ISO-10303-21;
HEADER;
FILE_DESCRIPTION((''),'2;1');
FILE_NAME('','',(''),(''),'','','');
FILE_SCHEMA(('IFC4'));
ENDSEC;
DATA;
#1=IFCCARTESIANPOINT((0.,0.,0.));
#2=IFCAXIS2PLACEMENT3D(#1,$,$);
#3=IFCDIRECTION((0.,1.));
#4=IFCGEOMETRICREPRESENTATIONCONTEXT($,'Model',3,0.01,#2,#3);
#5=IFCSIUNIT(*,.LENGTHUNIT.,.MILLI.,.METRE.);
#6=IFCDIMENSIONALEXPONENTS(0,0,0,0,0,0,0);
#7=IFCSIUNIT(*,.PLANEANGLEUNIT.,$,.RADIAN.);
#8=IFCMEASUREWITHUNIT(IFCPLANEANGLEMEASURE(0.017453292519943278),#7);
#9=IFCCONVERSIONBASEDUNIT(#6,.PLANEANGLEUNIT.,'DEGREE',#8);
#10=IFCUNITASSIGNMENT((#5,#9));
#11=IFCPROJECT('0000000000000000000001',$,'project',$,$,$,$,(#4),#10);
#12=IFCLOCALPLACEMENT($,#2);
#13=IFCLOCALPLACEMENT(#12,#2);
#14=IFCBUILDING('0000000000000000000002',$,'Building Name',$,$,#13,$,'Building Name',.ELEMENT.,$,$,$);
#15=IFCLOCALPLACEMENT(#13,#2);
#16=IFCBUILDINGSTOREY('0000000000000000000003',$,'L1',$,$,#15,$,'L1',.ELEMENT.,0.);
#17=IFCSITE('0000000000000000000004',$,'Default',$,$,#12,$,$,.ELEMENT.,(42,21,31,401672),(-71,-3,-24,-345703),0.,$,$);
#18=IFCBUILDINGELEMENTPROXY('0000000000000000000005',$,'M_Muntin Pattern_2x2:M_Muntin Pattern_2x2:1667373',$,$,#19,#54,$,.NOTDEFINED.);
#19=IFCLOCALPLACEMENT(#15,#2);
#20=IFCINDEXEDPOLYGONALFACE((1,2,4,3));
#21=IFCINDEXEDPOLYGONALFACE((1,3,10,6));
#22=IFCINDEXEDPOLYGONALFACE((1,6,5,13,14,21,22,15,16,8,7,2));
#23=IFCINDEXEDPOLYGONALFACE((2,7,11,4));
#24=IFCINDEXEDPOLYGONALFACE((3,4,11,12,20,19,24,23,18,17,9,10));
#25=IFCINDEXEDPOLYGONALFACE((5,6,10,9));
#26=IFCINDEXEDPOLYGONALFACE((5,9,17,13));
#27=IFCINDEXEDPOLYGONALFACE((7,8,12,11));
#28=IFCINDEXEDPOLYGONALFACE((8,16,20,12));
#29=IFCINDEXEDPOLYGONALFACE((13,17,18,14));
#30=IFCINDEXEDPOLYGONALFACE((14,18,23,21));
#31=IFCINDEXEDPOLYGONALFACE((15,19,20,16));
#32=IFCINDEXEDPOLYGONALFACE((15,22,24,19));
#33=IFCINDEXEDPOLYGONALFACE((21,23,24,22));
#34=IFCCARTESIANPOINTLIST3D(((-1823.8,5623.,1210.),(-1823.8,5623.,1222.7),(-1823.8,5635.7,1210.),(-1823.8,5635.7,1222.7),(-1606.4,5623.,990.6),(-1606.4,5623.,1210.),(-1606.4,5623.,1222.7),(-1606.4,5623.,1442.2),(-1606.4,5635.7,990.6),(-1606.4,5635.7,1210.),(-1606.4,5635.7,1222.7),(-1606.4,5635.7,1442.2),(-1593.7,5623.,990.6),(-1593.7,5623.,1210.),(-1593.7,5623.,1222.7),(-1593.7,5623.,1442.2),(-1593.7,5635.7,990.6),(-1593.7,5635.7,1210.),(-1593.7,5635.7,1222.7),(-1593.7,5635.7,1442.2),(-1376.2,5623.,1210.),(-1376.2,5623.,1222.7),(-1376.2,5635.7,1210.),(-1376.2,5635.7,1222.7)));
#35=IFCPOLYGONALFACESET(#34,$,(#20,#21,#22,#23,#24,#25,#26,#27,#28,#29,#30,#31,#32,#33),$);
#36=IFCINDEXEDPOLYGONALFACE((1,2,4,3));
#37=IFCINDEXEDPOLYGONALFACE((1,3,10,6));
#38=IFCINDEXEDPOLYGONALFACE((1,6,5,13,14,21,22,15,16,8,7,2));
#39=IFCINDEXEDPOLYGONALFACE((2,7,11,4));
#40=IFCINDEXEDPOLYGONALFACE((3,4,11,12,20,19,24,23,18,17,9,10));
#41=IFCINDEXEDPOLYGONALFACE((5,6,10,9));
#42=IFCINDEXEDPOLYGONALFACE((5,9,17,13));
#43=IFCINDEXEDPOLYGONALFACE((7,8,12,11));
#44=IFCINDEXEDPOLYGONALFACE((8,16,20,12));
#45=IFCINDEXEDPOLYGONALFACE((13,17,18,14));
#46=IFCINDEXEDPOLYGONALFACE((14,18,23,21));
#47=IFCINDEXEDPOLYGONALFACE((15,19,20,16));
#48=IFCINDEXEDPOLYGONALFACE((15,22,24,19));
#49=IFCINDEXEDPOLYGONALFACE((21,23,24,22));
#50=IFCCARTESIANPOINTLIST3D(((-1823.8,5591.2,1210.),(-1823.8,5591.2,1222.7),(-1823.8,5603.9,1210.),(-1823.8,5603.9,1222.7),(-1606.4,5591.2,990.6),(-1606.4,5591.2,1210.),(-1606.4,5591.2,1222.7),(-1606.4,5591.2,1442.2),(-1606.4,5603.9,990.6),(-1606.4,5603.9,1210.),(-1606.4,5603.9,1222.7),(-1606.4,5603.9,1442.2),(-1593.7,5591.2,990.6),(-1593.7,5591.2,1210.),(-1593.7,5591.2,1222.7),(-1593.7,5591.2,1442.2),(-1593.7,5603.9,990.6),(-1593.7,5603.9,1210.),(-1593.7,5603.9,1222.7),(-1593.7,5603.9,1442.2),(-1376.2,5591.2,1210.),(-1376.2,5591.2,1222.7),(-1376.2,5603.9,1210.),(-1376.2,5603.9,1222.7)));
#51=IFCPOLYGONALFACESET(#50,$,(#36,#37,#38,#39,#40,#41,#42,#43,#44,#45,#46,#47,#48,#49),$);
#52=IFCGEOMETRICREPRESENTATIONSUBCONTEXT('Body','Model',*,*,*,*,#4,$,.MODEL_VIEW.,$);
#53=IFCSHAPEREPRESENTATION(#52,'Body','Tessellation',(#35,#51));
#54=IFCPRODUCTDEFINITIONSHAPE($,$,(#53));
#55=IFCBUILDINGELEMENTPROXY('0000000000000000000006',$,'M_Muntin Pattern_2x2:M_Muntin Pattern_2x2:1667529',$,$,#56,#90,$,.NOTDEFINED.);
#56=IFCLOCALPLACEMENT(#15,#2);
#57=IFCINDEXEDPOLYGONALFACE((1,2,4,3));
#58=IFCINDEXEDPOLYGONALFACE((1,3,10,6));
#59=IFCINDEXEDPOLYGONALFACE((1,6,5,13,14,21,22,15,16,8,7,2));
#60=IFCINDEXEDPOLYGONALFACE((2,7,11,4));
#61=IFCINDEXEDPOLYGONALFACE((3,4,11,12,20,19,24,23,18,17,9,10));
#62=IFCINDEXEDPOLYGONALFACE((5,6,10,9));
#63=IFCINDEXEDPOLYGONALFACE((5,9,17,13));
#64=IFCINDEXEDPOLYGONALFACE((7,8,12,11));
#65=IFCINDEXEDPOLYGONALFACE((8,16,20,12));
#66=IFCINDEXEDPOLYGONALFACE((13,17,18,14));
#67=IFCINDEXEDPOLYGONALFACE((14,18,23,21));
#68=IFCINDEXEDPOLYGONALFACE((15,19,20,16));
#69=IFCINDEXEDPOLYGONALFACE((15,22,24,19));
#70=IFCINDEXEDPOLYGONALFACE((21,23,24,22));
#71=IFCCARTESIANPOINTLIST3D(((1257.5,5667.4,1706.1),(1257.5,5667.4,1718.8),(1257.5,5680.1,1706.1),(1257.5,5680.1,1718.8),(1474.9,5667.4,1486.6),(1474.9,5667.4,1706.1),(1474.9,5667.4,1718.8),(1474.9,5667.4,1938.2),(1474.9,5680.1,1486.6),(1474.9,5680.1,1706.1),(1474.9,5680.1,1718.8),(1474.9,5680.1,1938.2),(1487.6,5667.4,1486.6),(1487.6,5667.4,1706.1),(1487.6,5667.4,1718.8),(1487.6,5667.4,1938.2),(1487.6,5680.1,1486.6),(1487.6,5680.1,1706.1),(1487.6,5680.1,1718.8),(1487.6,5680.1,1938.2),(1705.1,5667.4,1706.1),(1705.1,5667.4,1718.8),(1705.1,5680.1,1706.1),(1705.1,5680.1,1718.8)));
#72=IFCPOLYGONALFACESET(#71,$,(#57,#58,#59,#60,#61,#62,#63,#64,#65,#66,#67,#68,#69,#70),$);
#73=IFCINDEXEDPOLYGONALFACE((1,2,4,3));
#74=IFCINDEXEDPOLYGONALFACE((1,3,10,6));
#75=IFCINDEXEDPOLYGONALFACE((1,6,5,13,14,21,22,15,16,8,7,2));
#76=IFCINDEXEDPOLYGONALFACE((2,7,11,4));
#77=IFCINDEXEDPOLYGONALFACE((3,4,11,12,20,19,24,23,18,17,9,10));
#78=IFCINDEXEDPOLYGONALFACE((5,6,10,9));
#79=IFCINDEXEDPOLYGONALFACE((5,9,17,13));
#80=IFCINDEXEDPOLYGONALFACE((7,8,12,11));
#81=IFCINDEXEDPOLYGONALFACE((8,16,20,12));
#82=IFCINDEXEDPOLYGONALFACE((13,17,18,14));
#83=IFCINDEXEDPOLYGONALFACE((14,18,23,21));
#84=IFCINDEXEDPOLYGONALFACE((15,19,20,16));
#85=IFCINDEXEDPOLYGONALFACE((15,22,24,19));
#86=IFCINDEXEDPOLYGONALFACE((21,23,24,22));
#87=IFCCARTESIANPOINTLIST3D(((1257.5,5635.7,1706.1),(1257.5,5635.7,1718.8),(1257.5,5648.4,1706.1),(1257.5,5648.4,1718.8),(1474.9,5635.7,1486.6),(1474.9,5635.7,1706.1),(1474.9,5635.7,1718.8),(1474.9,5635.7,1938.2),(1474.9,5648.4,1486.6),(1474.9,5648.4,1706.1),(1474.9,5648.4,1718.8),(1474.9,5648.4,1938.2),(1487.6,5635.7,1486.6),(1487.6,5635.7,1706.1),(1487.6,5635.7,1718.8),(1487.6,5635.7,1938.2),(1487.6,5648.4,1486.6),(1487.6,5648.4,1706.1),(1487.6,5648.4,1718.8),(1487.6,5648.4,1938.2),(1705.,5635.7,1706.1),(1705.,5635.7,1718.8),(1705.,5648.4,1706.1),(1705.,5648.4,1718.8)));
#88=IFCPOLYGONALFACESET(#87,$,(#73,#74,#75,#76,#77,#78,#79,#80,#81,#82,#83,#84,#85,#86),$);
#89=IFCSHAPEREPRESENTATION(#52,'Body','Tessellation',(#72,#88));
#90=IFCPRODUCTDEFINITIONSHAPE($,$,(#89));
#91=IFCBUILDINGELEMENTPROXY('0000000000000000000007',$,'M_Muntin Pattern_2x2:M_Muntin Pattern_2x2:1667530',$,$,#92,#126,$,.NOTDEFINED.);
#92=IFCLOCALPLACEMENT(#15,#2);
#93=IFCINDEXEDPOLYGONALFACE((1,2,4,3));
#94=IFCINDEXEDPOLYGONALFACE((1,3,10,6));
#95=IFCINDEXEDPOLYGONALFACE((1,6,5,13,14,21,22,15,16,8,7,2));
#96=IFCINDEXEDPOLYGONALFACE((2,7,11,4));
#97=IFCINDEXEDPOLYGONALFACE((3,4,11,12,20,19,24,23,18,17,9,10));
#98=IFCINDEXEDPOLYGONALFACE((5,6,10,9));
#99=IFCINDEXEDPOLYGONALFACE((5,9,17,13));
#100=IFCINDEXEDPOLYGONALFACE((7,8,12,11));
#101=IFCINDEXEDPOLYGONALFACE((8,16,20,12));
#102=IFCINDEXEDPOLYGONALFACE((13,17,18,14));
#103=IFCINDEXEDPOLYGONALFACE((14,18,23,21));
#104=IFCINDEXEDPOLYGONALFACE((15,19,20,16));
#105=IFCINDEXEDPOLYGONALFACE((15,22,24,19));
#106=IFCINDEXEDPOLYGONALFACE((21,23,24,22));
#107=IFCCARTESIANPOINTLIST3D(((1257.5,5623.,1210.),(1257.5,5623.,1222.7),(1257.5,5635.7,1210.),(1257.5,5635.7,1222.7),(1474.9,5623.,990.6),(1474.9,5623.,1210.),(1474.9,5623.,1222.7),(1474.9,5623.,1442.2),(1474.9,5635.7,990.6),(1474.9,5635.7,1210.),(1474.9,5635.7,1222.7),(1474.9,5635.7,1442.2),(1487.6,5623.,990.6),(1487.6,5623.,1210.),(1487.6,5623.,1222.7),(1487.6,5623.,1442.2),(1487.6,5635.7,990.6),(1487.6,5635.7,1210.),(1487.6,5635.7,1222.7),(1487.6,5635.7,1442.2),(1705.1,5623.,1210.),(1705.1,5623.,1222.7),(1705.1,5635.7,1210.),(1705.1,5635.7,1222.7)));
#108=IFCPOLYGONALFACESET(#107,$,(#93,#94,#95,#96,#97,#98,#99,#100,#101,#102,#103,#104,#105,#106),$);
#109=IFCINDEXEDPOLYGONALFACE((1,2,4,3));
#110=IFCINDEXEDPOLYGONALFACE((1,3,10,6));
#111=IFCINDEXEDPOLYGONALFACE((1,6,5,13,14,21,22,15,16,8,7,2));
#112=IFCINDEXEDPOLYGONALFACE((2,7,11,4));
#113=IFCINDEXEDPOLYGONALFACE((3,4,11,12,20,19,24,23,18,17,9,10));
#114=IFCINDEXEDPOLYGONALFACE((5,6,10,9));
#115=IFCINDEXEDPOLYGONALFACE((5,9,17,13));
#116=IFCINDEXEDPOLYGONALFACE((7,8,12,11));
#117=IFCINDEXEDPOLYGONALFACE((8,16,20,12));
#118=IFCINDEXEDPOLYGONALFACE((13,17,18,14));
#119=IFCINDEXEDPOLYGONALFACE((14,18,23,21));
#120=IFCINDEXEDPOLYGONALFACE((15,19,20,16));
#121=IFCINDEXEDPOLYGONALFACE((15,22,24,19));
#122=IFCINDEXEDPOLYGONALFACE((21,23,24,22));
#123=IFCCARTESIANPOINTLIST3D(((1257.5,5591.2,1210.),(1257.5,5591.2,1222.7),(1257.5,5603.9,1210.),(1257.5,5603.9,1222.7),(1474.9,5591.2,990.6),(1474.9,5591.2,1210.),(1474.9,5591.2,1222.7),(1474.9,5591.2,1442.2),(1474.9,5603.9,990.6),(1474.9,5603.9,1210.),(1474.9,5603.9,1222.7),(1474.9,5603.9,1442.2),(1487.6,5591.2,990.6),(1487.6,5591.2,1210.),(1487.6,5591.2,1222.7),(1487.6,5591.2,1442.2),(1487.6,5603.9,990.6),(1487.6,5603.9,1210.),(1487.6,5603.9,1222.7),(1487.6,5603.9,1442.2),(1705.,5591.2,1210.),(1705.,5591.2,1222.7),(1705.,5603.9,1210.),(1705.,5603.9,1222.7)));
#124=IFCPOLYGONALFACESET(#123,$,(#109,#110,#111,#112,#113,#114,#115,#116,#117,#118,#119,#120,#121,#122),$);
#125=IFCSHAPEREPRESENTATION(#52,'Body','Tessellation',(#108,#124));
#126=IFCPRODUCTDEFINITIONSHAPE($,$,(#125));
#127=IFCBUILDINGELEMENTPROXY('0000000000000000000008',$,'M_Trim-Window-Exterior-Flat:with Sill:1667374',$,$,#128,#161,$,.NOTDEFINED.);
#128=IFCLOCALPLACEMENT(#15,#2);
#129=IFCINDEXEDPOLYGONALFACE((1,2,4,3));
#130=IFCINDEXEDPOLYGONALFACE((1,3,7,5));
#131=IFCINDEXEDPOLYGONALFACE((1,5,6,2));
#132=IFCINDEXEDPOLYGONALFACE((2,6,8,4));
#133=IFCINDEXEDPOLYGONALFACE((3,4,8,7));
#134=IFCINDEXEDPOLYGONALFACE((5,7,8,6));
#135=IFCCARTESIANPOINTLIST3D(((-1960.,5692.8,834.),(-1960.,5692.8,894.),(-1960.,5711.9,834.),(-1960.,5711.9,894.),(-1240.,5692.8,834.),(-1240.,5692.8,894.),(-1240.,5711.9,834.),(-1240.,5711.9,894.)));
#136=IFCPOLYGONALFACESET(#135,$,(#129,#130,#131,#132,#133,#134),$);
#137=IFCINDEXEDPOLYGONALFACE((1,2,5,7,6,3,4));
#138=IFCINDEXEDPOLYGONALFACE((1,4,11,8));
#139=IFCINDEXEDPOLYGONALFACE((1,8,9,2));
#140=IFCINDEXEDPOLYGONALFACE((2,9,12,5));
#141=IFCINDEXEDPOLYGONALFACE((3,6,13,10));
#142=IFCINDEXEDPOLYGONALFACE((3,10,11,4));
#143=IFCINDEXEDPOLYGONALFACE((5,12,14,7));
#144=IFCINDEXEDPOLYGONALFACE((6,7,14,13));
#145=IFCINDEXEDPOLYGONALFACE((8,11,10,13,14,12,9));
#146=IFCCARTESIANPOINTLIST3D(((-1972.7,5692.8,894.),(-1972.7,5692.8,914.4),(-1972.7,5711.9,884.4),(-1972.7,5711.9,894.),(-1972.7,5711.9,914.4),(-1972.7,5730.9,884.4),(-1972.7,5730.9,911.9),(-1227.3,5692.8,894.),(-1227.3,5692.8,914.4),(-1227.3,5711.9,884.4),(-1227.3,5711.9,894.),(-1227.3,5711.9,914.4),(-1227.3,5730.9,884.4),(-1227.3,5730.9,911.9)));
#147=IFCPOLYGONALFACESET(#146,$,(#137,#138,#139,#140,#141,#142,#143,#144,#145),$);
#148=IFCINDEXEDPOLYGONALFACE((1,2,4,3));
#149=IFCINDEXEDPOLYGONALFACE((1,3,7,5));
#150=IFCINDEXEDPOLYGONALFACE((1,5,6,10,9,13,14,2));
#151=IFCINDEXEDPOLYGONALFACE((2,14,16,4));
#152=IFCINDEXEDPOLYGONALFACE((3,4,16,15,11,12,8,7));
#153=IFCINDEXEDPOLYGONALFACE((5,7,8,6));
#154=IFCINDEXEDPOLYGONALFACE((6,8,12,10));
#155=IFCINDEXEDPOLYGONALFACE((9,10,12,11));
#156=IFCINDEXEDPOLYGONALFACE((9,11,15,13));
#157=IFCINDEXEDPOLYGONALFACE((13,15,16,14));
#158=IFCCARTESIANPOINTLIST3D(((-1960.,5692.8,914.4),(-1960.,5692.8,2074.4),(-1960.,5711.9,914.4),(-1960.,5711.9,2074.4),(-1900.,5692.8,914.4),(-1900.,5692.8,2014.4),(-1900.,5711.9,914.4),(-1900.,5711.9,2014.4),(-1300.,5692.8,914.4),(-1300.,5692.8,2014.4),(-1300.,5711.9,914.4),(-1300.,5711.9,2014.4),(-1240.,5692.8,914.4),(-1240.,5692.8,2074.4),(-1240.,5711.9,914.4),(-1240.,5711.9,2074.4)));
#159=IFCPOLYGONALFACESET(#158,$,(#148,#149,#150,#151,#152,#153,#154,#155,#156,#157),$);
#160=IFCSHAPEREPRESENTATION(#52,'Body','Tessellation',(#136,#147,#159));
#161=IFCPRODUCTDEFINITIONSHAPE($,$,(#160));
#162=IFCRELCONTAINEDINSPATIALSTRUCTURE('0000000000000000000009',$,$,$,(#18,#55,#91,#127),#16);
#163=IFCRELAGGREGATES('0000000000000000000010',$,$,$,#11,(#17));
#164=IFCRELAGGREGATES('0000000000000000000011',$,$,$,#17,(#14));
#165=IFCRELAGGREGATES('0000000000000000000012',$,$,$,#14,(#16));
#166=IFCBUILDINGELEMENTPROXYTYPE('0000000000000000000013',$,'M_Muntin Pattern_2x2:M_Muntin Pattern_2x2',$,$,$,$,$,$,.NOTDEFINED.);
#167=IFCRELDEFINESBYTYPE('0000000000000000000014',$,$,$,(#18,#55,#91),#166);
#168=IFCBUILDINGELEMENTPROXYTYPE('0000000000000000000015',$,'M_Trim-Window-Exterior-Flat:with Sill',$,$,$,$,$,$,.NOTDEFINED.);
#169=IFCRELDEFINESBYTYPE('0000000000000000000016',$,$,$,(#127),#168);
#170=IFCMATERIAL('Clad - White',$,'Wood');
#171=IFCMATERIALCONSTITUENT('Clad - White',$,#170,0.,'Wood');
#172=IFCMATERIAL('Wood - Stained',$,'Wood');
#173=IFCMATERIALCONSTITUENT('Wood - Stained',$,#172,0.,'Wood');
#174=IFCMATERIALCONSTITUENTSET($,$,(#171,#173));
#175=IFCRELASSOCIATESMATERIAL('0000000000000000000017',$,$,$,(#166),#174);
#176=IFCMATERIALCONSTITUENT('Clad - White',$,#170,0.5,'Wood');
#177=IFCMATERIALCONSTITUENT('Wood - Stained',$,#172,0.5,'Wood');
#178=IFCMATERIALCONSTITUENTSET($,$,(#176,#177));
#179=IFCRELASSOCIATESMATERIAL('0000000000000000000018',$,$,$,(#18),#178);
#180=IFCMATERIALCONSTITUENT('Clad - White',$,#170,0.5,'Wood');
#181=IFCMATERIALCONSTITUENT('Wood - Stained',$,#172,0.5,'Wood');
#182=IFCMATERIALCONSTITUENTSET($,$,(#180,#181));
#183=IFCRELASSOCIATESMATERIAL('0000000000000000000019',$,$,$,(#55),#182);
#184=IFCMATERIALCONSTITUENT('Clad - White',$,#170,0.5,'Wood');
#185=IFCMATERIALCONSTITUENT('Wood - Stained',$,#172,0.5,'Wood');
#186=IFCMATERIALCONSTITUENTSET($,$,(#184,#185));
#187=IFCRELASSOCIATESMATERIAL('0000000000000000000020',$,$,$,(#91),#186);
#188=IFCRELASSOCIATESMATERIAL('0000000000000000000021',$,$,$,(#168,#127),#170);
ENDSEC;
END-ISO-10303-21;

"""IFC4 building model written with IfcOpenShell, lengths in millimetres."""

from ifc_helpers import new_model, entity, si_unit, converted_unit, direction, frame, origin, place, context, subcontext, project, spatial, indexed_curve, outline, extrude, source, transform, mapped, material, constituent, constituent_set, type_object, type_shapes, element, save


model = new_model("IFC4")

# Units and contexts
model_context = context("Model", 3, precision=0.01, world=origin(), true_north=direction((0.0, 1.0)))
body_context = subcontext(model_context, "Body", "Model", "MODEL_VIEW")
ifc_project = project(units=[si_unit("LENGTHUNIT", "METRE", prefix="MILLI"), converted_unit("PLANEANGLEUNIT", "DEGREE", entity("IfcPlaneAngleMeasure", 0.017453292519943278), si_unit("PLANEANGLEUNIT", "RADIAN"), dimensions=[0, 0, 0, 0, 0, 0, 0])], contexts=[model_context])

# Site, building, storey
site_placement = place(None, origin())
site = spatial("IfcSite", under=ifc_project, at=site_placement, Name="Default", CompositionType="ELEMENT", RefLatitude=(42, 21, 31, 401672), RefLongitude=(-71, -3, -24, -345703), RefElevation=0.0)
building_placement = place(site_placement, origin())
building = spatial("IfcBuilding", under=site, at=building_placement, Name="Building Name", LongName="Building Name", CompositionType="ELEMENT")
storey_placement = place(building_placement, origin())
storey = spatial("IfcBuildingStorey", under=building, at=storey_placement, Name="L1", LongName="L1", CompositionType="ELEMENT", Elevation=0.0)

# Building element proxies
ifc_material_1 = material(Name="Clad - White", Category="Wood")
ifc_material_2 = material(Name="Wood - Stained", Category="Wood")
ifc_constituent_1 = constituent(ifc_material_1, Name="Clad - White", Category="Wood", fraction=0.0)
ifc_constituent_2 = constituent(ifc_material_2, Name="Wood - Stained", Category="Wood", fraction=0.0)
ifc_constituent_set_1 = constituent_set(constituents=[ifc_constituent_1, ifc_constituent_2])
building_element_proxy_type_1 = type_object("IfcBuildingElementProxyType", Name="M_Muntin Pattern_2x2:M_Muntin Pattern_2x2", PredefinedType="NOTDEFINED", material=ifc_constituent_set_1)
shared_shape_1 = source(origin(), body_context, "Body", "SweptSolid", [
    extrude(outline(indexed_curve([(6.4, -6.4), (225.8, -6.4), (225.8, 6.3), (6.4, 6.3), (6.4, 223.8), (-6.3, 223.8), (-6.3, 6.3), (-225.8, 6.3), (-225.8, -6.4), (-6.3, -6.4), (-6.3, -223.8), (6.4, -223.8), (6.4, -6.4)], self_intersect=False)), frame((0.0, 9.5, 225.8), z_axis=(0.0, 1.0, 0.0), x_axis=(0.0, 0.0, 1.0)), (0.0, 0.0, 1.0), 12.7),
    extrude(outline(indexed_curve([(6.4, -6.4), (225.8, -6.4), (225.8, 6.3), (6.4, 6.3), (6.4, 223.8), (-6.3, 223.8), (-6.3, 6.3), (-225.8, 6.3), (-225.8, -6.4), (-6.3, -6.4), (-6.3, -223.8), (6.4, -223.8), (6.4, -6.4)], self_intersect=False)), frame((0.0, -22.2, 225.8), z_axis=(0.0, 1.0, 0.0), x_axis=(0.0, 0.0, 1.0)), (0.0, 0.0, 1.0), 12.7),
])
type_shapes(building_element_proxy_type_1, [shared_shape_1])
ifc_constituent_3 = constituent(ifc_material_1, Name="Clad - White", Category="Wood", fraction=0.5)
ifc_constituent_4 = constituent(ifc_material_2, Name="Wood - Stained", Category="Wood", fraction=0.5)
ifc_constituent_set_2 = constituent_set(constituents=[ifc_constituent_3, ifc_constituent_4])
proxy_1_placement = place(storey_placement, frame((-1600.0, 5613.5, 990.6)))
element("IfcBuildingElementProxy", 1, at=proxy_1_placement, inside=storey, type_object=building_element_proxy_type_1, material=ifc_constituent_set_2, Name="M_Muntin Pattern_2x2:M_Muntin Pattern_2x2:1667373", PredefinedType="NOTDEFINED", context=body_context, shape_type="MappedRepresentation", body=[
    mapped(shared_shape_1, transform((0.0, 0.0, 0.0), scale=1.0)),
])
ifc_constituent_5 = constituent(ifc_material_1, Name="Clad - White", Category="Wood", fraction=0.5)
ifc_constituent_6 = constituent(ifc_material_2, Name="Wood - Stained", Category="Wood", fraction=0.5)
ifc_constituent_set_3 = constituent_set(constituents=[ifc_constituent_5, ifc_constituent_6])
proxy_2_placement = place(storey_placement, frame((1481.2, 5657.9, 1486.6)))
element("IfcBuildingElementProxy", 2, at=proxy_2_placement, inside=storey, type_object=building_element_proxy_type_1, material=ifc_constituent_set_3, Name="M_Muntin Pattern_2x2:M_Muntin Pattern_2x2:1667529", PredefinedType="NOTDEFINED", context=body_context, shape_type="MappedRepresentation", body=[
    mapped(shared_shape_1, transform((0.0, 0.0, 0.0), scale=1.0)),
])
ifc_constituent_7 = constituent(ifc_material_1, Name="Clad - White", Category="Wood", fraction=0.5)
ifc_constituent_8 = constituent(ifc_material_2, Name="Wood - Stained", Category="Wood", fraction=0.5)
ifc_constituent_set_4 = constituent_set(constituents=[ifc_constituent_7, ifc_constituent_8])
proxy_3_placement = place(storey_placement, frame((1481.2, 5613.5, 990.6)))
element("IfcBuildingElementProxy", 3, at=proxy_3_placement, inside=storey, type_object=building_element_proxy_type_1, material=ifc_constituent_set_4, Name="M_Muntin Pattern_2x2:M_Muntin Pattern_2x2:1667530", PredefinedType="NOTDEFINED", context=body_context, shape_type="MappedRepresentation", body=[
    mapped(shared_shape_1, transform((0.0, 0.0, 0.0), scale=1.0)),
])
building_element_proxy_type_2 = type_object("IfcBuildingElementProxyType", Name="M_Trim-Window-Exterior-Flat:with Sill", PredefinedType="NOTDEFINED", material=ifc_material_1)
shared_shape_2 = source(origin(), body_context, "Body", "SweptSolid", [
    extrude(outline(indexed_curve([(-360.0, -30.0), (360.0, -30.0), (360.0, 30.0), (-360.0, 30.0), (-360.0, -30.0)], self_intersect=False)), frame((0.0, -1150.4, 0.0), z_axis=(0.0, 0.0, 1.0), x_axis=(-1.0, 0.0, 0.0)), (0.0, 0.0, 1.0), 19.0),
    extrude(outline(indexed_curve([(-19.0, -15.2), (0.0, -15.2), (0.0, -5.7), (19.0, -5.7), (19.0, 14.8), (0.0, 14.8), (-19.0, 12.3), (-19.0, -15.2)], self_intersect=False)), frame((-372.7, -1114.8, 19.0), z_axis=(1.0, 0.0, 0.0), x_axis=(0.0, 0.0, -1.0)), (0.0, 0.0, 1.0), 745.4),
    extrude(outline(indexed_curve([(-595.0, -360.0), (565.0, -360.0), (565.0, -300.0), (-535.0, -300.0), (-535.0, 300.0), (565.0, 300.0), (565.0, 360.0), (-595.0, 360.0), (-595.0, -360.0)], self_intersect=False)), frame((0.0, -535.0, 0.0), z_axis=(0.0, 0.0, 1.0), x_axis=(0.0, -1.0, 0.0)), (0.0, 0.0, 1.0), 19.0),
])
type_shapes(building_element_proxy_type_2, [shared_shape_2])
for number, where, z_axis, x_axis, name in (
    (4, (-1600.0, 5692.8, 2014.4), (0.0, 1.0, 0.0), (-1.0, 0.0, 0.0), "M_Trim-Window-Exterior-Flat:with Sill:1667374"),
):
    element("IfcBuildingElementProxy", number, at=place(storey_placement, frame(where, z_axis=z_axis, x_axis=x_axis)), inside=storey, type_object=building_element_proxy_type_2, material=ifc_material_1, Name=name, PredefinedType="NOTDEFINED", context=body_context, shape_type="MappedRepresentation", body=[
        mapped(shared_shape_2, transform((0.0, 0.0, 0.0), scale=1.0)),
    ])

save(model, "model.ifc")
